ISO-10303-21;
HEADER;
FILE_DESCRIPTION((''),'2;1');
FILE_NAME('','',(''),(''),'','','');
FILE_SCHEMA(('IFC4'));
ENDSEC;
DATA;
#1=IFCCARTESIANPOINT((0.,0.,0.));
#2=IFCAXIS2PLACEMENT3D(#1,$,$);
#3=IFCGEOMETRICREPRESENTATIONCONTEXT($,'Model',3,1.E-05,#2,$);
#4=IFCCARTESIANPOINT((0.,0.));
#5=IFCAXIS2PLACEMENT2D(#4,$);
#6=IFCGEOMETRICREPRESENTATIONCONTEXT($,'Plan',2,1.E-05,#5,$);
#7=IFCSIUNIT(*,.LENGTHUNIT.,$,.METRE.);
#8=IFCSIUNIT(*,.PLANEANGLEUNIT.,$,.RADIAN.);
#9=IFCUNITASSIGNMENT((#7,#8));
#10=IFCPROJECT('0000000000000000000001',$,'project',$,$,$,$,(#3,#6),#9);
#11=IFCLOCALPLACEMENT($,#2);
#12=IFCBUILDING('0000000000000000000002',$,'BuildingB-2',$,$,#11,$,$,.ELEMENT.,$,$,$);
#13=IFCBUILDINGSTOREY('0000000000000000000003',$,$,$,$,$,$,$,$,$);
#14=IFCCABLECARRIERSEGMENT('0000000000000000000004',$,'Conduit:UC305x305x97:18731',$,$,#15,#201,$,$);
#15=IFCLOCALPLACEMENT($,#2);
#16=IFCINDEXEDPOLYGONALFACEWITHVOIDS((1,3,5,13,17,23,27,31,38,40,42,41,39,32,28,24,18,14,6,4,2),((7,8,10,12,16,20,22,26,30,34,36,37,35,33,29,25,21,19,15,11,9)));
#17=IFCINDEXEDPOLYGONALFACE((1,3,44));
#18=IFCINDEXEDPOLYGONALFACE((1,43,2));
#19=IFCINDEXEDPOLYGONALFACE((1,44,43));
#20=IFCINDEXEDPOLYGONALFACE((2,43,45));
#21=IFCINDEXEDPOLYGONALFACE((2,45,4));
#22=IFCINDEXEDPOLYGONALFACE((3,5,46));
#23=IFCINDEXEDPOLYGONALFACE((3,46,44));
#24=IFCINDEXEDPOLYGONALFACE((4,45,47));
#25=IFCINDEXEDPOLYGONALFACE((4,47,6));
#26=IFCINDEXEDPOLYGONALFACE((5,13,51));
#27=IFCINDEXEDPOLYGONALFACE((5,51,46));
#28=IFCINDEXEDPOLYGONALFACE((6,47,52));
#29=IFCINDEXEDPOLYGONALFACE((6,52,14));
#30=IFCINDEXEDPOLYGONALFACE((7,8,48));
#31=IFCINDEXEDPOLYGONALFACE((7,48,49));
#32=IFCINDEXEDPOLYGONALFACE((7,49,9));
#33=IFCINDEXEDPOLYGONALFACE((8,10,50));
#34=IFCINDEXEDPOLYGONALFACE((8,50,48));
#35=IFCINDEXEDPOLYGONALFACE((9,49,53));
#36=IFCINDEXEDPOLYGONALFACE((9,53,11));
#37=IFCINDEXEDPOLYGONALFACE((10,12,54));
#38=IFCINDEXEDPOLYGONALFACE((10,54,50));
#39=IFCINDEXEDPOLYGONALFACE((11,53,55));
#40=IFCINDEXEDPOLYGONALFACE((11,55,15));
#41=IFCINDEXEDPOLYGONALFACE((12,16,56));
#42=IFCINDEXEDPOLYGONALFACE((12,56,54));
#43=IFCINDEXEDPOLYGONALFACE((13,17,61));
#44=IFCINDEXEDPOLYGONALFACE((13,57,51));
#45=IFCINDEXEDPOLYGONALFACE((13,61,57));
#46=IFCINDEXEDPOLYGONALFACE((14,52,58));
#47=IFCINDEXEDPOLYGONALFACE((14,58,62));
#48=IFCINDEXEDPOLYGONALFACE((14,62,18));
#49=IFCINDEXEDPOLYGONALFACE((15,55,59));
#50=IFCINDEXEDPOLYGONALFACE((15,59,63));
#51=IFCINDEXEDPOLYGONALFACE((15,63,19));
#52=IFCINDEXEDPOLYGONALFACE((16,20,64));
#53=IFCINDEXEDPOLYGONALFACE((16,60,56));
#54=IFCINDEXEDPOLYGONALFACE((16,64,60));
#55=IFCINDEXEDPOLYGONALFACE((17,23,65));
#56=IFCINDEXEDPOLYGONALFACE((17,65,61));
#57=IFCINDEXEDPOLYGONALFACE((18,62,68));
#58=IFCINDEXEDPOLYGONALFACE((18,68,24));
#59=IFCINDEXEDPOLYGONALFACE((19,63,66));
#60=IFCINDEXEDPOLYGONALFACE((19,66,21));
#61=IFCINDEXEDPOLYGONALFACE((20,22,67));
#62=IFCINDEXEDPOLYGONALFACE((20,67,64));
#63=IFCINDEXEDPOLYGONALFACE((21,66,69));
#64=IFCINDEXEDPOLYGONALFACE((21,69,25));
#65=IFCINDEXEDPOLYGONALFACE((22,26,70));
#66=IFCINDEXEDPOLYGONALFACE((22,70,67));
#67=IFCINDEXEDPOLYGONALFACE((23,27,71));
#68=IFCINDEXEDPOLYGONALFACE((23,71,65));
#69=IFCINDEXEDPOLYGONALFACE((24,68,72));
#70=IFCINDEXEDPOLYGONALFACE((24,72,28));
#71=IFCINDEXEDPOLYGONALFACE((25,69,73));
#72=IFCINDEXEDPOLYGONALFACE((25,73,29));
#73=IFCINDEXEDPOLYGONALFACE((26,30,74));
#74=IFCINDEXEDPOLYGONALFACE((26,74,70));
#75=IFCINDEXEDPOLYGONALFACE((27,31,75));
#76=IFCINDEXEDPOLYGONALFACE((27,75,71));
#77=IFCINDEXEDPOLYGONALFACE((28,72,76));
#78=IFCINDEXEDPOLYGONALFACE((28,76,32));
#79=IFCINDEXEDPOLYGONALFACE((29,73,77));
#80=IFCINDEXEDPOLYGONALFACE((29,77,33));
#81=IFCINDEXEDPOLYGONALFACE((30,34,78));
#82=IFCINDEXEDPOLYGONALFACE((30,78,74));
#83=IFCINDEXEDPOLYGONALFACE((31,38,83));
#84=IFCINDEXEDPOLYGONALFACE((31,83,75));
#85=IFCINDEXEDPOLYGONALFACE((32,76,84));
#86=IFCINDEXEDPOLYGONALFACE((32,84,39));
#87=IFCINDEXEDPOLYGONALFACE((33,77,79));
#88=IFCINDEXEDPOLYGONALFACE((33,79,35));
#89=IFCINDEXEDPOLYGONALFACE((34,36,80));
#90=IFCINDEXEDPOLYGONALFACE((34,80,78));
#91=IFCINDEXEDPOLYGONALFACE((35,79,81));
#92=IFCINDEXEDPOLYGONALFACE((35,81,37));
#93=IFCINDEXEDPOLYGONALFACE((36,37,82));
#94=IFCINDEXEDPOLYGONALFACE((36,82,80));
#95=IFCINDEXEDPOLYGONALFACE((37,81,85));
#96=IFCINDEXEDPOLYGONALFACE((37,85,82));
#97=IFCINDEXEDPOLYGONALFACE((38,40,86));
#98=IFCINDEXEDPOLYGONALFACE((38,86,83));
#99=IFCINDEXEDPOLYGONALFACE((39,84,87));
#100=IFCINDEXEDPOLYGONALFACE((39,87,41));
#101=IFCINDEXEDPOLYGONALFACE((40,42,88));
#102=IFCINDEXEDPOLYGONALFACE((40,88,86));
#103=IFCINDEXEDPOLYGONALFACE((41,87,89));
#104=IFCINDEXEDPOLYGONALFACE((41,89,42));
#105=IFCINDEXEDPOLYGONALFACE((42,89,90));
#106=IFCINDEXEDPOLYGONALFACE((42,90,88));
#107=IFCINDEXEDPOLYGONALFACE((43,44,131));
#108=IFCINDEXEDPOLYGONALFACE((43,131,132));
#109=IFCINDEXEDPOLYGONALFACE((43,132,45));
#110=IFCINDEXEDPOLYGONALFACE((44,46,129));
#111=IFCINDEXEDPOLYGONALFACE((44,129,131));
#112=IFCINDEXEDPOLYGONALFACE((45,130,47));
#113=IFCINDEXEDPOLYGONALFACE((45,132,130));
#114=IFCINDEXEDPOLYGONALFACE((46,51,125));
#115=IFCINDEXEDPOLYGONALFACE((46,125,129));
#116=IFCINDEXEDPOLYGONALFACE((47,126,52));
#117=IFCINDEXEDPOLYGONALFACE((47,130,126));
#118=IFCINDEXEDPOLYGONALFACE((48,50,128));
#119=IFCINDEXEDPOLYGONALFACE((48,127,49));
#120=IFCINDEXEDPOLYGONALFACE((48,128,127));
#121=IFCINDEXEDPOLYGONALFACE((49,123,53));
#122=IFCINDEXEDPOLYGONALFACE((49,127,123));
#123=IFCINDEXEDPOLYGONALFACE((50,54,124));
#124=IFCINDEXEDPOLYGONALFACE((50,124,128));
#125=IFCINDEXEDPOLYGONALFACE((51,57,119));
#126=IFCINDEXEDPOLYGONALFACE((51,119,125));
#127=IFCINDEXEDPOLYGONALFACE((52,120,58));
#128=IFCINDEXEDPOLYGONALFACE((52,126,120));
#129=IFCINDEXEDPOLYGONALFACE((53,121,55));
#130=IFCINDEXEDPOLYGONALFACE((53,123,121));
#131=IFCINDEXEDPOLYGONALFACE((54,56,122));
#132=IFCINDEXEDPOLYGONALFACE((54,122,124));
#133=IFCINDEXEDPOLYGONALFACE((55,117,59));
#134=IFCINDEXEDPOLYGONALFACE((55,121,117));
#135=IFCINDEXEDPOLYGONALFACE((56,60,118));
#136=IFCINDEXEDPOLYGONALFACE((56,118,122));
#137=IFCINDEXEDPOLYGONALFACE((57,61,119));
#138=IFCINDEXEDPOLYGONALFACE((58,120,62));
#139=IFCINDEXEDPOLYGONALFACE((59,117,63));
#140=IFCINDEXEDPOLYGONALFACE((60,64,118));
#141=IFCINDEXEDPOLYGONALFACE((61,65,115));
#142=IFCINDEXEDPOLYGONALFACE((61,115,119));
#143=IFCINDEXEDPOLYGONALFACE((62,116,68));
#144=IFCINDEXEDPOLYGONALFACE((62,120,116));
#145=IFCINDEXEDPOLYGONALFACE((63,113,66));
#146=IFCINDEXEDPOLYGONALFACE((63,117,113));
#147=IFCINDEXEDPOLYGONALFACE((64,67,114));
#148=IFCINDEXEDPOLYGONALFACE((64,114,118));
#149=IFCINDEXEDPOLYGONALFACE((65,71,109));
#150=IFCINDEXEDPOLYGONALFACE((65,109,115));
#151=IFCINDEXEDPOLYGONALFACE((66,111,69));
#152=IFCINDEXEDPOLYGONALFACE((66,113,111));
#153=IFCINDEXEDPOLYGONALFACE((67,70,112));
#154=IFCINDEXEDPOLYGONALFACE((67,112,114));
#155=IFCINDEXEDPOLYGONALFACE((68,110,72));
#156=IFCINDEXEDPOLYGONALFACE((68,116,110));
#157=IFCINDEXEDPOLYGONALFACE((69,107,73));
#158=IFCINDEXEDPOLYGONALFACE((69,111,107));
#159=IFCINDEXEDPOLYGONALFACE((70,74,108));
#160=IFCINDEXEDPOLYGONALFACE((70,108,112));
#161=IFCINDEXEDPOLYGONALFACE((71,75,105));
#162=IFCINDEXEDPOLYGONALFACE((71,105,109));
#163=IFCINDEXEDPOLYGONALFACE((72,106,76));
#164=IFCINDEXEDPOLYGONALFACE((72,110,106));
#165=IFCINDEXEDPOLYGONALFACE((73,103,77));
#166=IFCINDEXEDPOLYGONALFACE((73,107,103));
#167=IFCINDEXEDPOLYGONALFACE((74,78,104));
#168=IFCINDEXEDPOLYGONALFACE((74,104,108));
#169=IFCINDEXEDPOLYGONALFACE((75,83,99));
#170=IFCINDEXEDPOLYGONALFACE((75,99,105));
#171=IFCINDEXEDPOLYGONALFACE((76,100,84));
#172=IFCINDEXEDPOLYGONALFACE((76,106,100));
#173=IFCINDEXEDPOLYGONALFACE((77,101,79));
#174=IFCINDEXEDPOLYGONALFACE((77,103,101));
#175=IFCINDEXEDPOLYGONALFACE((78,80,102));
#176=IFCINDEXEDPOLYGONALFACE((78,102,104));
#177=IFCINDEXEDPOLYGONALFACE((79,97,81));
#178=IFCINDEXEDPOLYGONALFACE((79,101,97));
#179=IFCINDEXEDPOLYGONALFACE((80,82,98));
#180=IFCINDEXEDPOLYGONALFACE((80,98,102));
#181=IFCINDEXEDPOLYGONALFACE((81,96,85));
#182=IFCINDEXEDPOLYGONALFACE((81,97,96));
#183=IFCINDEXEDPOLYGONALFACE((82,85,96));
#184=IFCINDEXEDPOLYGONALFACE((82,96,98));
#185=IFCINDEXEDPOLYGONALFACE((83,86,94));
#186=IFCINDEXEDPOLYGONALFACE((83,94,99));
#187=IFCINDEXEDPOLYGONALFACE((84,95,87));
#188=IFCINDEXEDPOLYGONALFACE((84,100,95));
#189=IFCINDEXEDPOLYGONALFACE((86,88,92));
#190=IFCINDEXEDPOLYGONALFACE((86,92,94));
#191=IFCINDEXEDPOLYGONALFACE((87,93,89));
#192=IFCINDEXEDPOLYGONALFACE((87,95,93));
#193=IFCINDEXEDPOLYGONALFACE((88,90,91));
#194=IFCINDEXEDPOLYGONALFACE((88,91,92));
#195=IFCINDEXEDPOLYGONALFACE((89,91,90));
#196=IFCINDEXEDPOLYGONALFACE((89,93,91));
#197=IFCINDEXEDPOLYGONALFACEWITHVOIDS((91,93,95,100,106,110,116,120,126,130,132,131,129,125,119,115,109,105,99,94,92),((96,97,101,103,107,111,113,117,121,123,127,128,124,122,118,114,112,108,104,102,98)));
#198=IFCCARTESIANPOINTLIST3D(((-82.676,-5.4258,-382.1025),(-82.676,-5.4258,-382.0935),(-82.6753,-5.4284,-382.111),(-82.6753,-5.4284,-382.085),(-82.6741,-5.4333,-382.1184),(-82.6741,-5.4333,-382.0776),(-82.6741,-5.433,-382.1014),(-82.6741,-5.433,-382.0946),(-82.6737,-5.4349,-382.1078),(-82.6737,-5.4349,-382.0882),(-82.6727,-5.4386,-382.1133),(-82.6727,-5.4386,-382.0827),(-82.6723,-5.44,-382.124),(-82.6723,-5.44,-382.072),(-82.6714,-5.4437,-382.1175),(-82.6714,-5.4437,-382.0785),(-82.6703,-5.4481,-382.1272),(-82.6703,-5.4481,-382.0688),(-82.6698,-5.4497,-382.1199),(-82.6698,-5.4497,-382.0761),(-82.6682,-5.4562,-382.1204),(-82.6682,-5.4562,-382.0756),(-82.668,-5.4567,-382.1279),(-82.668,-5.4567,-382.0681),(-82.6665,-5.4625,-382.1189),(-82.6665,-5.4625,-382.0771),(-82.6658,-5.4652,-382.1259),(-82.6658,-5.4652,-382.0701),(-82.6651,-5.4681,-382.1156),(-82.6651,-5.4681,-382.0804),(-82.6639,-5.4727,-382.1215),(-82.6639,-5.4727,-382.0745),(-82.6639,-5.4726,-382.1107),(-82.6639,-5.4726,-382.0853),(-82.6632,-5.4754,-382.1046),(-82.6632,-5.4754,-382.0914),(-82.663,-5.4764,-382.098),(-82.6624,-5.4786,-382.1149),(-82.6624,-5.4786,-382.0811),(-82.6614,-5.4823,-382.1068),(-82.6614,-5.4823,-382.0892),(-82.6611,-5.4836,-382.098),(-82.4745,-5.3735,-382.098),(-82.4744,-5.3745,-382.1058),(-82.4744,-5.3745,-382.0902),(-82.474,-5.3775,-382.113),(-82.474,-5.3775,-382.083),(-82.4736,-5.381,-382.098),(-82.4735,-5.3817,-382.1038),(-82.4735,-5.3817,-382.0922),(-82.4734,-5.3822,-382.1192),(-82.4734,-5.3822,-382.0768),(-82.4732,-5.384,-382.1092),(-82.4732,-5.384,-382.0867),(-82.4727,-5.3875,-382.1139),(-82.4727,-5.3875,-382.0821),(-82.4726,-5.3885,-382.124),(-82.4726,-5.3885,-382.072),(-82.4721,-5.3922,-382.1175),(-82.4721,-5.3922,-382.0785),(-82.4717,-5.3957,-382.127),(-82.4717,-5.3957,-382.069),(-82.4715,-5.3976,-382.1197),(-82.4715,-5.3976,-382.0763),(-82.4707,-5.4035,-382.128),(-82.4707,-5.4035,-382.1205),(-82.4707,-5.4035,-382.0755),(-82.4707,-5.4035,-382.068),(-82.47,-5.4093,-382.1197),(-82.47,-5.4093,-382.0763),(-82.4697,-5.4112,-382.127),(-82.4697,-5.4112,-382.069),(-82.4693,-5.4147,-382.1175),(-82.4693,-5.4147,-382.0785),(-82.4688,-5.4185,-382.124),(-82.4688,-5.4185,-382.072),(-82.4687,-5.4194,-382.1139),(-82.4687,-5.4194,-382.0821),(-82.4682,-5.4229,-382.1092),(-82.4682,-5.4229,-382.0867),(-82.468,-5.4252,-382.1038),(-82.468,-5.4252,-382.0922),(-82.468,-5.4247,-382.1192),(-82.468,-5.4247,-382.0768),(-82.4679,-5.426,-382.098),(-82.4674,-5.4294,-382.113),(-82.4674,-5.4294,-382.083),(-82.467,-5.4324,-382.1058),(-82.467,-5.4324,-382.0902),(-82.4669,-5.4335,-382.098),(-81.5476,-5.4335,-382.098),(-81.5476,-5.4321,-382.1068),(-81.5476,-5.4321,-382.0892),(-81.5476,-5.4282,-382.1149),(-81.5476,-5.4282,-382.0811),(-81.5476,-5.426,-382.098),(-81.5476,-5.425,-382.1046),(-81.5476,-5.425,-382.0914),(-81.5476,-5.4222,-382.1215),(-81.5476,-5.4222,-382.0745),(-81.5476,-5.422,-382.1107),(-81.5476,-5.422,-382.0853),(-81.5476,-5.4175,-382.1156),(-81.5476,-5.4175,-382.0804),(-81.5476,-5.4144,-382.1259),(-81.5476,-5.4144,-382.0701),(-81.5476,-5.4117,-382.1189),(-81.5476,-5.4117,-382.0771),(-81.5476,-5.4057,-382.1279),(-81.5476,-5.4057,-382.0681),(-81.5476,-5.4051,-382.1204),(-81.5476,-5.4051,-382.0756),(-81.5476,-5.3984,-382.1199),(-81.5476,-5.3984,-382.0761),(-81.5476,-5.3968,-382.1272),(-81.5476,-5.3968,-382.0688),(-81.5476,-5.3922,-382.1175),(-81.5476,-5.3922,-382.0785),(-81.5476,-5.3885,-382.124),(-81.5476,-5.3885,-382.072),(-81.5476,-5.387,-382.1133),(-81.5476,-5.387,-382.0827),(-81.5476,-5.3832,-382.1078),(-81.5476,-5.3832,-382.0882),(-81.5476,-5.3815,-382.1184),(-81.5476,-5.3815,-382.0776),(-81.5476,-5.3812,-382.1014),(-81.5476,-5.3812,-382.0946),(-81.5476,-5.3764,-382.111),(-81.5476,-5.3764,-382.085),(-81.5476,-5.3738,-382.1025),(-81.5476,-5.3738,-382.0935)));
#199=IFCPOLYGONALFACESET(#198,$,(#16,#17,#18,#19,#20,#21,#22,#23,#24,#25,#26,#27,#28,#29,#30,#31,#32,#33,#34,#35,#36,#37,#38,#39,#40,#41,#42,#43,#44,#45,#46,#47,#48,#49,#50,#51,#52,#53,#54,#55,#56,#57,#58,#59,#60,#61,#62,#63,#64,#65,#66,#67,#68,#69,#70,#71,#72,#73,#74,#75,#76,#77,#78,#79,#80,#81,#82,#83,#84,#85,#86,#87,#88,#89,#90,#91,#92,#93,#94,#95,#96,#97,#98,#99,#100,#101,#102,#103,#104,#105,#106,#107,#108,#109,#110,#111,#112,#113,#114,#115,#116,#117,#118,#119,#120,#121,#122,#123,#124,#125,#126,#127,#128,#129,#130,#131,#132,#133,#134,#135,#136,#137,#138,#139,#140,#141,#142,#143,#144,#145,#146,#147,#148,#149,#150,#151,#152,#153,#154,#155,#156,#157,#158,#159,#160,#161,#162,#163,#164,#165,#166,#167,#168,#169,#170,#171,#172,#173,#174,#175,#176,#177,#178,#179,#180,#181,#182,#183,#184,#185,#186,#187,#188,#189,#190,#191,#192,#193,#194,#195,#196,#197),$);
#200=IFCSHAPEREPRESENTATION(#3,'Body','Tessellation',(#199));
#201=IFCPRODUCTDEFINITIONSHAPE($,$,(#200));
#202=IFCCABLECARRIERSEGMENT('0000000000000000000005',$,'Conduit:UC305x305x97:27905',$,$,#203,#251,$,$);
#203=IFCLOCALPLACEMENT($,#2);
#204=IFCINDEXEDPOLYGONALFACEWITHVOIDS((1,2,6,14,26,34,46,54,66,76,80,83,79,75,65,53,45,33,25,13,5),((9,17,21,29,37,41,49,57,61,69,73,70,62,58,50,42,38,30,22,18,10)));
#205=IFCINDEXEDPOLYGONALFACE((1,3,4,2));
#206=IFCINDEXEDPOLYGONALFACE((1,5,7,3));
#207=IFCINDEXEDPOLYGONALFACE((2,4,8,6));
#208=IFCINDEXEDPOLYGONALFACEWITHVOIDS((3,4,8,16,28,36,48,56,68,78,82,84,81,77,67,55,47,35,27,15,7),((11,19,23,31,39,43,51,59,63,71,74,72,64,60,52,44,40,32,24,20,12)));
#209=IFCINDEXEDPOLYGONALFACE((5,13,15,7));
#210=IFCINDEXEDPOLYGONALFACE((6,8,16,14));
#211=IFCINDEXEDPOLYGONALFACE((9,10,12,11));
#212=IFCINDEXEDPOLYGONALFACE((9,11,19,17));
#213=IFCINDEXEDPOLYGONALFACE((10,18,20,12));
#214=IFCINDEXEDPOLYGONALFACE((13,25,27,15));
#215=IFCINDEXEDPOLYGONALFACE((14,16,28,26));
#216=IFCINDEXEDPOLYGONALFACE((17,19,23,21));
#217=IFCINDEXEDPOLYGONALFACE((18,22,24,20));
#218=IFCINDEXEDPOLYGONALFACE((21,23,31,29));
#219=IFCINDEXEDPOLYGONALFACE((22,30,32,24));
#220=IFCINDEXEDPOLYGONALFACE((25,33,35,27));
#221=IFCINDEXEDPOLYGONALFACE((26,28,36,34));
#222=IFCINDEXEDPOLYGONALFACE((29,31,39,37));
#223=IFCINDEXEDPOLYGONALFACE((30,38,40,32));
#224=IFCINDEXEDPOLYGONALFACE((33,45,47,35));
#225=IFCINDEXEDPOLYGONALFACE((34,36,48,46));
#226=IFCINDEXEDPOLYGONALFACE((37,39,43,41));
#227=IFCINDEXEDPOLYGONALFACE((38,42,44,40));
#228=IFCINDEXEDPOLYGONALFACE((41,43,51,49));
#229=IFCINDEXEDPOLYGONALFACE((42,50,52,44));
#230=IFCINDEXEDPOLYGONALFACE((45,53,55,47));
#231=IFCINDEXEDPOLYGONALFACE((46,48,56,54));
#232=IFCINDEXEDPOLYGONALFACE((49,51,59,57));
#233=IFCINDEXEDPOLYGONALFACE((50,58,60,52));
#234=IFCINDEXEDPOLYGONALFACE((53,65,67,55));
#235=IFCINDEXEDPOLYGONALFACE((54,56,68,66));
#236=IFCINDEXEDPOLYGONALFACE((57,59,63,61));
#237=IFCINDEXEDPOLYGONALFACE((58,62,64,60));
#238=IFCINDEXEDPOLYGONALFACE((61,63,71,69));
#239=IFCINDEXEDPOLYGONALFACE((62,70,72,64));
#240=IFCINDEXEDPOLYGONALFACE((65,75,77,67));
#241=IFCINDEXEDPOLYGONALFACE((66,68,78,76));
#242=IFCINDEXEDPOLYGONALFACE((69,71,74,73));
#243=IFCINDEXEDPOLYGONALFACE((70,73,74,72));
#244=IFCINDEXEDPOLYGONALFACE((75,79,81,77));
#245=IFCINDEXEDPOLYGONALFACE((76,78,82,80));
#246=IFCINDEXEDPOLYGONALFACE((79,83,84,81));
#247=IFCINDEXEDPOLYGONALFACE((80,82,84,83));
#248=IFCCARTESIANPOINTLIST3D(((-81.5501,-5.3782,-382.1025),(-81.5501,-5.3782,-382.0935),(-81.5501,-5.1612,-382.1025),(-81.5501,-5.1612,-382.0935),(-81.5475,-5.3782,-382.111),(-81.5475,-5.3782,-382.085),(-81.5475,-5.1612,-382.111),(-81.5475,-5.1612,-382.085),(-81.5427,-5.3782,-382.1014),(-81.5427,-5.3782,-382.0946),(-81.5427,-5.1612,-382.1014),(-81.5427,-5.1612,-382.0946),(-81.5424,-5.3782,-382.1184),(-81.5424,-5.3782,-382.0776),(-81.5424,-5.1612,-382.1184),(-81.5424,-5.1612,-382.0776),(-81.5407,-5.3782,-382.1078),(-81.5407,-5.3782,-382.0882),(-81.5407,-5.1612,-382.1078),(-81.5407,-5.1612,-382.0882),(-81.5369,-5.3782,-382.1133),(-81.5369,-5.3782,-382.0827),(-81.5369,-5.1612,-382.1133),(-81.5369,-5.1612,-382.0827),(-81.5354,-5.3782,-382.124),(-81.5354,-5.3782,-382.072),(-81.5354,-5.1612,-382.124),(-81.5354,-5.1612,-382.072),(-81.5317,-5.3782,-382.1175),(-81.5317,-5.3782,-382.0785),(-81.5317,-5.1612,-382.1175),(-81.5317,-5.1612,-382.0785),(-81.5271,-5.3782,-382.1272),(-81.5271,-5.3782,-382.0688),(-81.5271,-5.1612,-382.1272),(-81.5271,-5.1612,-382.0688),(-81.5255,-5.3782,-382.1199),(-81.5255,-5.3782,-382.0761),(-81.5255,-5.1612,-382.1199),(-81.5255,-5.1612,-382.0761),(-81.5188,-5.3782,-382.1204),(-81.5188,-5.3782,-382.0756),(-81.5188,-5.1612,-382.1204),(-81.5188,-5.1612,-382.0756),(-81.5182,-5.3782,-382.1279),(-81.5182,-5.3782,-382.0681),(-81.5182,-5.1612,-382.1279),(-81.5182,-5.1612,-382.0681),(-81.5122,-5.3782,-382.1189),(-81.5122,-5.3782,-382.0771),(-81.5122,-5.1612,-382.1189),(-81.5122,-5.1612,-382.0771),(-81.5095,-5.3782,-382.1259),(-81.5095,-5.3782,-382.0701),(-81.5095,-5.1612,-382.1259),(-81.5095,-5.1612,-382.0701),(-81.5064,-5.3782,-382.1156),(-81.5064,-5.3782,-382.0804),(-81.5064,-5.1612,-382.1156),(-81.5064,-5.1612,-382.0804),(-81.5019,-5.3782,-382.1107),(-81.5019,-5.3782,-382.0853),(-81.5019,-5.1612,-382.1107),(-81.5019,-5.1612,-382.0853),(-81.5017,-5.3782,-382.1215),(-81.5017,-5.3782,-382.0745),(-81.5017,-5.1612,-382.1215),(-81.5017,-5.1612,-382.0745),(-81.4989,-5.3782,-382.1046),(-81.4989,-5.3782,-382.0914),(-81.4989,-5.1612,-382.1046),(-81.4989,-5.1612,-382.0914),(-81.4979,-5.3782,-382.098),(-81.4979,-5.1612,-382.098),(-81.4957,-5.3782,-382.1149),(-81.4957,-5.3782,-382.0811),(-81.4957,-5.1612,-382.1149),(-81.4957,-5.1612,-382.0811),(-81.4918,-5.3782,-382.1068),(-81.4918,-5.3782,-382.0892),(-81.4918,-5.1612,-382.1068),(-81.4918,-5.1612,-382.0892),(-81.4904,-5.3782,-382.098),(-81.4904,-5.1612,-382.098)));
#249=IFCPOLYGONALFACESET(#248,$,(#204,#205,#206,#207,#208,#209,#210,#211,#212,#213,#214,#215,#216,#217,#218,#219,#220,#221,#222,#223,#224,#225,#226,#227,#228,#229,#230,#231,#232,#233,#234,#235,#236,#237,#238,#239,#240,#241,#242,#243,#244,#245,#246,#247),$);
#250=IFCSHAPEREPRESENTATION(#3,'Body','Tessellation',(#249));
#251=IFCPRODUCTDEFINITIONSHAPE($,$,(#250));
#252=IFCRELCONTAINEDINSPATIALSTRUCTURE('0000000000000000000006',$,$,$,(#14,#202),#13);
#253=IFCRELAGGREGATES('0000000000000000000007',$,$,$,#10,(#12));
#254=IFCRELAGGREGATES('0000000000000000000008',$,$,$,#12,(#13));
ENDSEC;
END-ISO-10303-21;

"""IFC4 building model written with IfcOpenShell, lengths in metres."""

from ifc_helpers import new_model, entity, si_unit, origin, origin_2d, place, context, project, spatial, element, save


model = new_model("IFC4")

# Units and contexts
model_context = context("Model", 3, precision=1e-05, world=origin())
plan_context = context("Plan", 2, precision=1e-05, world=origin_2d())
ifc_project = project(units=[si_unit("LENGTHUNIT", "METRE"), si_unit("PLANEANGLEUNIT", "RADIAN")], contexts=[model_context, plan_context])

# Building, storey
building_placement = place(None, origin())
building = spatial("IfcBuilding", under=ifc_project, at=building_placement, Name="BuildingB-2", CompositionType="ELEMENT")
storey = spatial("IfcBuildingStorey", under=building)

# Cable carrier segments
element("IfcCableCarrierSegment", 1, inside=storey, Name="Conduit:UC305x305x97:18731", context=model_context, shape_type="AdvancedSweptSolid", body=[
    entity("IfcSweptDiskSolid", entity("IfcCompositeCurve", [entity("IfcCompositeCurveSegment", "CONTINUOUS", False, entity("IfcPolyline", [entity("IfcCartesianPoint", [83.0312, 5.429, 382.098]), entity("IfcCartesianPoint", [82.1081, 5.429, 382.098]), entity("IfcCartesianPoint", [81.9102, 5.3779, 382.098])]))], False), 0.03, 0.0225),
])
element("IfcCableCarrierSegment", 2, inside=storey, Name="Conduit:UC305x305x97:27905", context=model_context, shape_type="AdvancedSweptSolid", body=[
    entity("IfcSweptDiskSolid", entity("IfcCompositeCurve", [entity("IfcCompositeCurveSegment", "CONTINUOUS", False, entity("IfcPolyline", [entity("IfcCartesianPoint", [81.5204, 5.1612, 382.098]), entity("IfcCartesianPoint", [81.5204, 5.3782, 382.098])]))], False), 0.03, 0.0225),
])

save(model, "model.ifc")
